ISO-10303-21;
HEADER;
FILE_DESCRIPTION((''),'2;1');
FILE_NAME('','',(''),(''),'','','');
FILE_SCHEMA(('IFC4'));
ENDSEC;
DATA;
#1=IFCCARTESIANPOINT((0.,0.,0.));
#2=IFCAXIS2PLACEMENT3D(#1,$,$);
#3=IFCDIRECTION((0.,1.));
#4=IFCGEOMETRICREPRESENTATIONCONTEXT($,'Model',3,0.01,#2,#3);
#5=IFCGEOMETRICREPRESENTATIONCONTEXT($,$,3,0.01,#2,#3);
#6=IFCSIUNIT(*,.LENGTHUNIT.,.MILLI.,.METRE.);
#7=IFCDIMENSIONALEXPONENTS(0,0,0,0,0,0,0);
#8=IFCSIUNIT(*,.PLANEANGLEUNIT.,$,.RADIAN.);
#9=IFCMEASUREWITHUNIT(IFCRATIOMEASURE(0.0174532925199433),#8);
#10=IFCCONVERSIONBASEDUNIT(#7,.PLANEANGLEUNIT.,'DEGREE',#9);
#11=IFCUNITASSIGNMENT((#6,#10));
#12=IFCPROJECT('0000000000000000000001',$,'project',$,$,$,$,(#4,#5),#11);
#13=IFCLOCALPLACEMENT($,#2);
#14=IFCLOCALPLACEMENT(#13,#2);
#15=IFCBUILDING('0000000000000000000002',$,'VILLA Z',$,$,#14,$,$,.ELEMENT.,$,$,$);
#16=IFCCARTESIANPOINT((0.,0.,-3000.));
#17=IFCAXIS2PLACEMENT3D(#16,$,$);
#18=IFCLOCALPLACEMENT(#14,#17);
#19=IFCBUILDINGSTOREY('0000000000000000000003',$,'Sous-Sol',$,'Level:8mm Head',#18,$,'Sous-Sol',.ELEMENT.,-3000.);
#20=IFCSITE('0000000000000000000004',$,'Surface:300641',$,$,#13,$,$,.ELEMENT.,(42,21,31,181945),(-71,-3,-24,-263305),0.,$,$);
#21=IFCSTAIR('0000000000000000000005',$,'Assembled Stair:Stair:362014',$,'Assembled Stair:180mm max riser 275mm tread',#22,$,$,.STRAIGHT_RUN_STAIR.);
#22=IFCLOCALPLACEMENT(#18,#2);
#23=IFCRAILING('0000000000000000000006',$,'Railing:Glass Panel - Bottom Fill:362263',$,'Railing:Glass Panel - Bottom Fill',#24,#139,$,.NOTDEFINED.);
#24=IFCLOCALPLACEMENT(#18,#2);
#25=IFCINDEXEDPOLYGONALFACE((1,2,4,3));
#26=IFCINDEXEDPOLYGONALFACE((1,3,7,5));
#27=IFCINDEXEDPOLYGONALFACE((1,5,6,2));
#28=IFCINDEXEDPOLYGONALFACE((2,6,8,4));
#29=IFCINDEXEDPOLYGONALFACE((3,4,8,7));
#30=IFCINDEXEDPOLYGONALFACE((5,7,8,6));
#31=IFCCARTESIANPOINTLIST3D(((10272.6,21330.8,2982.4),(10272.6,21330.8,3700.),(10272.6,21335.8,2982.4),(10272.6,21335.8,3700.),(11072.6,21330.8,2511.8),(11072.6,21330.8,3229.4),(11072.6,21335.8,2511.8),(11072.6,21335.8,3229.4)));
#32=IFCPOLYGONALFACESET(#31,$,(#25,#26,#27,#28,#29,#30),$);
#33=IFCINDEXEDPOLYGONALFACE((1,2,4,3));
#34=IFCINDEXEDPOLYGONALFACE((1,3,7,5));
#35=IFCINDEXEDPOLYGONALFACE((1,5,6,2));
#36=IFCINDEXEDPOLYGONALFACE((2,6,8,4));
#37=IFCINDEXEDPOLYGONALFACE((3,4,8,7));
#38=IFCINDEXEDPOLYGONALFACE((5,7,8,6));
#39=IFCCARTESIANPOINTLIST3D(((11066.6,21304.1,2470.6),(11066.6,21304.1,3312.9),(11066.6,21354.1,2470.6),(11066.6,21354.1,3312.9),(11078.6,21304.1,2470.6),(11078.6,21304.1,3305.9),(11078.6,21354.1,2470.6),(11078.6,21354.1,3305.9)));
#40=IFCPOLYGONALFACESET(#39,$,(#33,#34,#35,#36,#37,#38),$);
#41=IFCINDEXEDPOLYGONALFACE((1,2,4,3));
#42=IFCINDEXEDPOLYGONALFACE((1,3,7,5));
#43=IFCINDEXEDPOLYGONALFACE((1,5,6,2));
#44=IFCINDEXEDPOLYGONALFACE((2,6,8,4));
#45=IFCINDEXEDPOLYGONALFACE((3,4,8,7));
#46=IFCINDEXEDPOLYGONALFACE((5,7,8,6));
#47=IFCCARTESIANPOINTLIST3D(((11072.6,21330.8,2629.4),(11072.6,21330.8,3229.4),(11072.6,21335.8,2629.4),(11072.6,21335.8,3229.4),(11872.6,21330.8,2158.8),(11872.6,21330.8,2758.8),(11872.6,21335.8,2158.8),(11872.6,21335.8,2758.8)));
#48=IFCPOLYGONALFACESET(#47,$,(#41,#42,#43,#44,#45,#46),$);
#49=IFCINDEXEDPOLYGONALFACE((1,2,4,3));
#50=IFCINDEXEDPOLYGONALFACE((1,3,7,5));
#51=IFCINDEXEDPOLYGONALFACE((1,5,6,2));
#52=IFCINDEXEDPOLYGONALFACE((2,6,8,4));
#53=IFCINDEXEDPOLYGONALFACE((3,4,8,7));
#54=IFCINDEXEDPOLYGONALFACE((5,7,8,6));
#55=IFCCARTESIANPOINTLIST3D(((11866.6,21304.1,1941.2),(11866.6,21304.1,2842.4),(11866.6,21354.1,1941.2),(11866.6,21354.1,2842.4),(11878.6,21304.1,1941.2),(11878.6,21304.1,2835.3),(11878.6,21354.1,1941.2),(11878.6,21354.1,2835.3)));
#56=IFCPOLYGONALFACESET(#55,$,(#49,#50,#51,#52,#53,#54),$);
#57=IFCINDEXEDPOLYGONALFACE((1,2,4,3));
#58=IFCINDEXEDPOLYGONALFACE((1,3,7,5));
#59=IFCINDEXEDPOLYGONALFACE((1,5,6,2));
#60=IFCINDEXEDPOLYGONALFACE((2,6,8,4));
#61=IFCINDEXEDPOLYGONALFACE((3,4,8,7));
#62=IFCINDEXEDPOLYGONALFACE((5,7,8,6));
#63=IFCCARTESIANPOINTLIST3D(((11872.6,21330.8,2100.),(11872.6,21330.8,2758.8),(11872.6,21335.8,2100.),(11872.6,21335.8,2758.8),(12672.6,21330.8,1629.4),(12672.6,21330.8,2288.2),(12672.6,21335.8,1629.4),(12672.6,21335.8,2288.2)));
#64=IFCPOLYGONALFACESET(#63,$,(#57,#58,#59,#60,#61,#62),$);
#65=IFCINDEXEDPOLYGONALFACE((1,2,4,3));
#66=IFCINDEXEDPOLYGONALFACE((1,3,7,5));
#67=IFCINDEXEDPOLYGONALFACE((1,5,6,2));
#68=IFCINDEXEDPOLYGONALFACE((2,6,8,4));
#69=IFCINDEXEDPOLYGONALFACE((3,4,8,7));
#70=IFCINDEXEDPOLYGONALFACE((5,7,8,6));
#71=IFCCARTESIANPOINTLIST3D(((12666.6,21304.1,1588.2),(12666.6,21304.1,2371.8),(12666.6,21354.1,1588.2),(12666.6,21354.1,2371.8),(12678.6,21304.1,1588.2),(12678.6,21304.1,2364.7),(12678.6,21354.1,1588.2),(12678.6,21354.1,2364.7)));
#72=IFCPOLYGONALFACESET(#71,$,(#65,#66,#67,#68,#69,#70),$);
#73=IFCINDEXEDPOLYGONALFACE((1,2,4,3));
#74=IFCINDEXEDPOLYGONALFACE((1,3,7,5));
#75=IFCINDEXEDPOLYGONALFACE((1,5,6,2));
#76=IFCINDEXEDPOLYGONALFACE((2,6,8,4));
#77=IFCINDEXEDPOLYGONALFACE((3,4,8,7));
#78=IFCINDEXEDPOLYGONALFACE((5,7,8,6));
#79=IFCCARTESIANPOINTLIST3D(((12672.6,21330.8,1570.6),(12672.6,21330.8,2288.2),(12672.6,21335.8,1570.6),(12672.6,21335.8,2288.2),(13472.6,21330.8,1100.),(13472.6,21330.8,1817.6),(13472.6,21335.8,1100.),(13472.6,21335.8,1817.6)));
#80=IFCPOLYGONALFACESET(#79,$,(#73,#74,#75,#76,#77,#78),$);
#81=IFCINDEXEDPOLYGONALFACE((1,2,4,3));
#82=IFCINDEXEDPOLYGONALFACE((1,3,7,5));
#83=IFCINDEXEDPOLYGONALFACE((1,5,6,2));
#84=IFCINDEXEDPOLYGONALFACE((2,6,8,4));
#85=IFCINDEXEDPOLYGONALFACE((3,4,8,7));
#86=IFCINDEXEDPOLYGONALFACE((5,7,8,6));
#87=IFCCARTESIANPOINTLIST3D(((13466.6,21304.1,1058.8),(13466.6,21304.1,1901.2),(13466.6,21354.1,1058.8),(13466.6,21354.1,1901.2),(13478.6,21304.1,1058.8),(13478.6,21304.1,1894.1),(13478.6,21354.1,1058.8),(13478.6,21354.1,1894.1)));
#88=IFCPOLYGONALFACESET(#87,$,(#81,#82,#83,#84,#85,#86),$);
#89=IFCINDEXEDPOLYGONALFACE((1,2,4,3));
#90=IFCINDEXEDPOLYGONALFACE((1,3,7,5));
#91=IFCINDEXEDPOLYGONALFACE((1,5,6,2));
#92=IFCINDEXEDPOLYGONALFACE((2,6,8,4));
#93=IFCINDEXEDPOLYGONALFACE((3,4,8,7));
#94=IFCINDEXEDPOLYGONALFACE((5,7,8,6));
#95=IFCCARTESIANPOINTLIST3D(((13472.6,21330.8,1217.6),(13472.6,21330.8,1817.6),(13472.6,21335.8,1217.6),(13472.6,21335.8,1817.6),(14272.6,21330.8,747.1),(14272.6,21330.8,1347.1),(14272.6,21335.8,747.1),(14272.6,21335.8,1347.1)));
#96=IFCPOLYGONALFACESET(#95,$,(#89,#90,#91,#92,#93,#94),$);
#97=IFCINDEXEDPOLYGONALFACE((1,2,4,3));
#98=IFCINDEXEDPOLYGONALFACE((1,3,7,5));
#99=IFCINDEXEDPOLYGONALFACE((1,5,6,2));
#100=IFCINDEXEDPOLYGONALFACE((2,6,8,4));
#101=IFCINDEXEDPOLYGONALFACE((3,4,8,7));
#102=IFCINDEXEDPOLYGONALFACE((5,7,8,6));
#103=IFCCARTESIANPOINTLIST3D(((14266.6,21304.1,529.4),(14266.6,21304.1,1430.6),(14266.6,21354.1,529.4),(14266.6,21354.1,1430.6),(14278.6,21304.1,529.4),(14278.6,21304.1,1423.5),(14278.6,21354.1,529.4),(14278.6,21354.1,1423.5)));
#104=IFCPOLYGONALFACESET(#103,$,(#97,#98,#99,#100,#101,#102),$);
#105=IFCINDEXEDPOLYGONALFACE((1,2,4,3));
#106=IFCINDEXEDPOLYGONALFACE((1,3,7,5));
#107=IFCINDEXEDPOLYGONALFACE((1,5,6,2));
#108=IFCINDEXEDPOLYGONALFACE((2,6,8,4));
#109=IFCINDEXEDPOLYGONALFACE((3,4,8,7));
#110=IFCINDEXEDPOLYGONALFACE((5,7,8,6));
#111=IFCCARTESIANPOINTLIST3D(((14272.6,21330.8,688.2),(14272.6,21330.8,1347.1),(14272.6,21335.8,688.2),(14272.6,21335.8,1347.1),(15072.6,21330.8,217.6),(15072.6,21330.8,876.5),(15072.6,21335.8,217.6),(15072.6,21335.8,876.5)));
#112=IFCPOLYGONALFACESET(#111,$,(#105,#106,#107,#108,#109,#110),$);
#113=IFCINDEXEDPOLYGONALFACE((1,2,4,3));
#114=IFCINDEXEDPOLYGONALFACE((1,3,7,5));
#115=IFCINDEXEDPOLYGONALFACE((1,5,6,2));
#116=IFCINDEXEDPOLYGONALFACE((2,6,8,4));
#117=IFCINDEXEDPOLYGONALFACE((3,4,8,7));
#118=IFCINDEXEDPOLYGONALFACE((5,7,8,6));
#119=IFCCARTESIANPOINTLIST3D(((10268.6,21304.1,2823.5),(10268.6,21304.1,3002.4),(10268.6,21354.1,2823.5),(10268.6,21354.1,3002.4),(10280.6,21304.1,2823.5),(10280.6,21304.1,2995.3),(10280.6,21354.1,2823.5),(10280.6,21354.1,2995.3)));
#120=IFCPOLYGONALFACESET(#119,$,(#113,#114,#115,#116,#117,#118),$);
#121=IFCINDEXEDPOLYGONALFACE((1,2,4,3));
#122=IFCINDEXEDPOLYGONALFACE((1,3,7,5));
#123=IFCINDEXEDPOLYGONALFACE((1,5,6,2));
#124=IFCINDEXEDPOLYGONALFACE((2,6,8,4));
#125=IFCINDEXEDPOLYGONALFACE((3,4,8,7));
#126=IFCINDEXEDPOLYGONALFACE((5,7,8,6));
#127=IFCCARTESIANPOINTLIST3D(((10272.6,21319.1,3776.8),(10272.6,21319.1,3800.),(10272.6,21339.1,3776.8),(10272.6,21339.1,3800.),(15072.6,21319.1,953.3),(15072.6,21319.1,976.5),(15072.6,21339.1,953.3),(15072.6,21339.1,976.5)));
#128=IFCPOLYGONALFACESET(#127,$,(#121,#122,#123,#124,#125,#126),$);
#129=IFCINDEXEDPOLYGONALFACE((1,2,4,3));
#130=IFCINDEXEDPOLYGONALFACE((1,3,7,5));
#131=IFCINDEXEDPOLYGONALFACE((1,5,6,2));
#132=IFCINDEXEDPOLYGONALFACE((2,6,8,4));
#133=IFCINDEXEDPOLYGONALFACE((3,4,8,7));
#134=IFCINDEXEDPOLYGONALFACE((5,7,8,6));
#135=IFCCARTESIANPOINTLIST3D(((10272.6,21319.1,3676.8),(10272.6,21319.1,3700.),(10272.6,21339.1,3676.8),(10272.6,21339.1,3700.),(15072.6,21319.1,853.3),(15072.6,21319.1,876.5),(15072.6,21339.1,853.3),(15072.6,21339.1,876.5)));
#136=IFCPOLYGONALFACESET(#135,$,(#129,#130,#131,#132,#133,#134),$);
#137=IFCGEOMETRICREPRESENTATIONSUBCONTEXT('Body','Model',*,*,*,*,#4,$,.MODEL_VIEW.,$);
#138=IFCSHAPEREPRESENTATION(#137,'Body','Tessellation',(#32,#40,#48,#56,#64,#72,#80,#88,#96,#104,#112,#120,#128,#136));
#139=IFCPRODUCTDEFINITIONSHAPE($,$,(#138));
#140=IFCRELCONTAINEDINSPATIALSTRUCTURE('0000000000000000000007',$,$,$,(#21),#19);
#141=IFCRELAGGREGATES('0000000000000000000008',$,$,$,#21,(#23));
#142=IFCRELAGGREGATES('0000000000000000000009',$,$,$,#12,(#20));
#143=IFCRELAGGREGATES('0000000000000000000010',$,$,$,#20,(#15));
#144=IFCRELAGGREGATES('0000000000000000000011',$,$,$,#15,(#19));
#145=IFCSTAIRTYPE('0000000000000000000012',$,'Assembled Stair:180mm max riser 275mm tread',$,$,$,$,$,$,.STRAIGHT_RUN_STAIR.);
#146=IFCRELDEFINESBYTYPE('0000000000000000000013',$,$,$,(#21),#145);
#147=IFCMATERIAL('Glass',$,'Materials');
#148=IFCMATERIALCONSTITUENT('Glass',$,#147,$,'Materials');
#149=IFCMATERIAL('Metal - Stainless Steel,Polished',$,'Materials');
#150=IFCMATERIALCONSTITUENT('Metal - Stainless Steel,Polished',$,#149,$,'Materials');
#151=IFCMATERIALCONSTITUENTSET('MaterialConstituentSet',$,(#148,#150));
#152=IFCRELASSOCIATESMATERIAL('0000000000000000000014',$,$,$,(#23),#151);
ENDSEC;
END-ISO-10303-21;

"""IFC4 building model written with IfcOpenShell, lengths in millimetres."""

from ifc_helpers import new_model, entity, si_unit, converted_unit, direction, frame, origin, place, context, subcontext, project, spatial, polyline, outline, extrude, material, constituent, constituent_set, type_object, element, aggregate, save


model = new_model("IFC4")

# Units and contexts
model_context = context("Model", 3, precision=0.01, world=origin(), true_north=direction((0.0, 1.0)))
context_of_model = context(None, 3, precision=0.01, world=origin(), true_north=direction((0.0, 1.0)))
body_context = subcontext(model_context, "Body", "Model", "MODEL_VIEW")
ifc_project = project(units=[si_unit("LENGTHUNIT", "METRE", prefix="MILLI"), converted_unit("PLANEANGLEUNIT", "DEGREE", entity("IfcRatioMeasure", 0.0174532925199433), si_unit("PLANEANGLEUNIT", "RADIAN"), dimensions=[0, 0, 0, 0, 0, 0, 0])], contexts=[model_context, context_of_model])

# Site, building, storey
site_placement = place(None, origin())
site = spatial("IfcSite", under=ifc_project, at=site_placement, Name="Surface:300641", CompositionType="ELEMENT", RefLatitude=(42, 21, 31, 181945), RefLongitude=(-71, -3, -24, -263305), RefElevation=0.0)
building_placement = place(site_placement, origin())
building = spatial("IfcBuilding", under=site, at=building_placement, Name="VILLA Z", CompositionType="ELEMENT")
storey_placement = place(building_placement, frame((0.0, 0.0, -3000.0)))
storey = spatial("IfcBuildingStorey", under=building, at=storey_placement, Name="Sous-Sol", ObjectType="Level:8mm Head", LongName="Sous-Sol", CompositionType="ELEMENT", Elevation=-3000.0)

# Stair
stair_type = type_object("IfcStairType", Name="Assembled Stair:180mm max riser 275mm tread", PredefinedType="STRAIGHT_RUN_STAIR")
stair_placement = place(storey_placement, origin())
stair = element("IfcStair", 1, at=stair_placement, inside=storey, type_object=stair_type, Name="Assembled Stair:Stair:362014", ObjectType="Assembled Stair:180mm max riser 275mm tread", PredefinedType="STRAIGHT_RUN_STAIR")

# Shared definitions
ifc_material_1 = material(Name="Glass", Category="Materials")

# Railing
ifc_constituent_1 = constituent(ifc_material_1, Name="Glass", Category="Materials")
ifc_material_2 = material(Name="Metal - Stainless Steel,Polished", Category="Materials")
ifc_constituent_2 = constituent(ifc_material_2, Name="Metal - Stainless Steel,Polished", Category="Materials")
ifc_constituent_set_1 = constituent_set(constituents=[ifc_constituent_1, ifc_constituent_2], Name="MaterialConstituentSet")
railing_1_placement = place(stair_placement, frame((10268.6, 21304.1, 217.6)))
railing_1 = element("IfcRailing", 2, at=railing_1_placement, material=ifc_constituent_set_1, Name="Railing:Glass Panel - Bottom Fill:362263", ObjectType="Railing:Glass Panel - Bottom Fill", PredefinedType="NOTDEFINED", context=body_context, shape_type="SweptSolid", body=[
    extrude(outline(polyline([(-123.5, -400.0), (594.1, -400.0), (123.5, 400.0), (-594.1, 400.0), (-123.5, -400.0)])), frame((404.0, 26.7, 2888.2), z_axis=(0.0, 1.0, 0.0), x_axis=(0.0, 0.0, -1.0)), (0.0, 0.0, 1.0), 5.0),
    extrude(outline(polyline([(-419.4, -6.0), (422.9, -6.0), (415.9, 6.0), (-419.4, 6.0), (-419.4, -6.0)])), frame((804.0, 0.0, 2672.4), z_axis=(0.0, 1.0, 0.0), x_axis=(0.0, 0.0, 1.0)), (0.0, 0.0, 1.0), 50.0),
    extrude(outline(polyline([(-64.7, -400.0), (535.3, -400.0), (64.7, 400.0), (-535.3, 400.0), (-64.7, -400.0)])), frame((1204.0, 26.7, 2476.5), z_axis=(0.0, 1.0, 0.0), x_axis=(0.0, 0.0, -1.0)), (0.0, 0.0, 1.0), 5.0),
    extrude(outline(polyline([(-448.8, -6.0), (452.4, -6.0), (445.3, 6.0), (-448.8, 6.0), (-448.8, -6.0)])), frame((1604.0, 0.0, 2172.4), z_axis=(0.0, 1.0, 0.0), x_axis=(0.0, 0.0, 1.0)), (0.0, 0.0, 1.0), 50.0),
    extrude(outline(polyline([(-94.1, -400.0), (564.7, -400.0), (94.1, 400.0), (-564.7, 400.0), (-94.1, -400.0)])), frame((2004.0, 26.7, 1976.5), z_axis=(0.0, 1.0, 0.0), x_axis=(0.0, 0.0, -1.0)), (0.0, 0.0, 1.0), 5.0),
    extrude(outline(polyline([(-390.0, -6.0), (393.5, -6.0), (386.5, 6.0), (-390.0, 6.0), (-390.0, -6.0)])), frame((2404.0, 0.0, 1760.6), z_axis=(0.0, 1.0, 0.0), x_axis=(0.0, 0.0, 1.0)), (0.0, 0.0, 1.0), 50.0),
    extrude(outline(polyline([(-123.5, -400.0), (594.1, -400.0), (123.5, 400.0), (-594.1, 400.0), (-123.5, -400.0)])), frame((2804.0, 26.7, 1476.5), z_axis=(0.0, 1.0, 0.0), x_axis=(0.0, 0.0, -1.0)), (0.0, 0.0, 1.0), 5.0),
    extrude(outline(polyline([(-419.4, -6.0), (422.9, -6.0), (415.9, 6.0), (-419.4, 6.0), (-419.4, -6.0)])), frame((3204.0, 0.0, 1260.6), z_axis=(0.0, 1.0, 0.0), x_axis=(0.0, 0.0, 1.0)), (0.0, 0.0, 1.0), 50.0),
    extrude(outline(polyline([(-64.7, -400.0), (535.3, -400.0), (64.7, 400.0), (-535.3, 400.0), (-64.7, -400.0)])), frame((3604.0, 26.7, 1064.7), z_axis=(0.0, 1.0, 0.0), x_axis=(0.0, 0.0, -1.0)), (0.0, 0.0, 1.0), 5.0),
    extrude(outline(polyline([(-448.8, -6.0), (452.4, -6.0), (445.3, 6.0), (-448.8, 6.0), (-448.8, -6.0)])), frame((4004.0, 0.0, 760.6), z_axis=(0.0, 1.0, 0.0), x_axis=(0.0, 0.0, 1.0)), (0.0, 0.0, 1.0), 50.0),
    extrude(outline(polyline([(-94.1, -400.0), (564.7, -400.0), (94.1, 400.0), (-564.7, 400.0), (-94.1, -400.0)])), frame((4404.0, 26.7, 564.7), z_axis=(0.0, 1.0, 0.0), x_axis=(0.0, 0.0, -1.0)), (0.0, 0.0, 1.0), 5.0),
    extrude(outline(polyline([(-87.6, -6.0), (91.2, -6.0), (84.1, 6.0), (-87.6, 6.0), (-87.6, -6.0)])), frame((6.0, 0.0, 2693.5), z_axis=(0.0, 1.0, 0.0), x_axis=(0.0, 0.0, 1.0)), (0.0, 0.0, 1.0), 50.0),
    extrude(outline(polyline([(-2790.3, -10.0), (2778.6, -10.0), (2790.3, 10.0), (-2778.6, 10.0), (-2790.3, -10.0)])), frame((2404.0, 15.0, 2159.0), z_axis=(0.0, 1.0, 0.0), x_axis=(-0.861934, 0.0, 0.50702)), (0.0, 0.0, 1.0), 20.0),
    extrude(outline(polyline([(-2790.3, -10.0), (2778.6, -10.0), (2790.3, 10.0), (-2778.6, 10.0), (-2790.3, -10.0)])), frame((2404.0, 15.0, 2059.0), z_axis=(0.0, 1.0, 0.0), x_axis=(-0.861934, 0.0, 0.50702)), (0.0, 0.0, 1.0), 20.0),
])
aggregate(stair, [railing_1])

save(model, "model.ifc")
